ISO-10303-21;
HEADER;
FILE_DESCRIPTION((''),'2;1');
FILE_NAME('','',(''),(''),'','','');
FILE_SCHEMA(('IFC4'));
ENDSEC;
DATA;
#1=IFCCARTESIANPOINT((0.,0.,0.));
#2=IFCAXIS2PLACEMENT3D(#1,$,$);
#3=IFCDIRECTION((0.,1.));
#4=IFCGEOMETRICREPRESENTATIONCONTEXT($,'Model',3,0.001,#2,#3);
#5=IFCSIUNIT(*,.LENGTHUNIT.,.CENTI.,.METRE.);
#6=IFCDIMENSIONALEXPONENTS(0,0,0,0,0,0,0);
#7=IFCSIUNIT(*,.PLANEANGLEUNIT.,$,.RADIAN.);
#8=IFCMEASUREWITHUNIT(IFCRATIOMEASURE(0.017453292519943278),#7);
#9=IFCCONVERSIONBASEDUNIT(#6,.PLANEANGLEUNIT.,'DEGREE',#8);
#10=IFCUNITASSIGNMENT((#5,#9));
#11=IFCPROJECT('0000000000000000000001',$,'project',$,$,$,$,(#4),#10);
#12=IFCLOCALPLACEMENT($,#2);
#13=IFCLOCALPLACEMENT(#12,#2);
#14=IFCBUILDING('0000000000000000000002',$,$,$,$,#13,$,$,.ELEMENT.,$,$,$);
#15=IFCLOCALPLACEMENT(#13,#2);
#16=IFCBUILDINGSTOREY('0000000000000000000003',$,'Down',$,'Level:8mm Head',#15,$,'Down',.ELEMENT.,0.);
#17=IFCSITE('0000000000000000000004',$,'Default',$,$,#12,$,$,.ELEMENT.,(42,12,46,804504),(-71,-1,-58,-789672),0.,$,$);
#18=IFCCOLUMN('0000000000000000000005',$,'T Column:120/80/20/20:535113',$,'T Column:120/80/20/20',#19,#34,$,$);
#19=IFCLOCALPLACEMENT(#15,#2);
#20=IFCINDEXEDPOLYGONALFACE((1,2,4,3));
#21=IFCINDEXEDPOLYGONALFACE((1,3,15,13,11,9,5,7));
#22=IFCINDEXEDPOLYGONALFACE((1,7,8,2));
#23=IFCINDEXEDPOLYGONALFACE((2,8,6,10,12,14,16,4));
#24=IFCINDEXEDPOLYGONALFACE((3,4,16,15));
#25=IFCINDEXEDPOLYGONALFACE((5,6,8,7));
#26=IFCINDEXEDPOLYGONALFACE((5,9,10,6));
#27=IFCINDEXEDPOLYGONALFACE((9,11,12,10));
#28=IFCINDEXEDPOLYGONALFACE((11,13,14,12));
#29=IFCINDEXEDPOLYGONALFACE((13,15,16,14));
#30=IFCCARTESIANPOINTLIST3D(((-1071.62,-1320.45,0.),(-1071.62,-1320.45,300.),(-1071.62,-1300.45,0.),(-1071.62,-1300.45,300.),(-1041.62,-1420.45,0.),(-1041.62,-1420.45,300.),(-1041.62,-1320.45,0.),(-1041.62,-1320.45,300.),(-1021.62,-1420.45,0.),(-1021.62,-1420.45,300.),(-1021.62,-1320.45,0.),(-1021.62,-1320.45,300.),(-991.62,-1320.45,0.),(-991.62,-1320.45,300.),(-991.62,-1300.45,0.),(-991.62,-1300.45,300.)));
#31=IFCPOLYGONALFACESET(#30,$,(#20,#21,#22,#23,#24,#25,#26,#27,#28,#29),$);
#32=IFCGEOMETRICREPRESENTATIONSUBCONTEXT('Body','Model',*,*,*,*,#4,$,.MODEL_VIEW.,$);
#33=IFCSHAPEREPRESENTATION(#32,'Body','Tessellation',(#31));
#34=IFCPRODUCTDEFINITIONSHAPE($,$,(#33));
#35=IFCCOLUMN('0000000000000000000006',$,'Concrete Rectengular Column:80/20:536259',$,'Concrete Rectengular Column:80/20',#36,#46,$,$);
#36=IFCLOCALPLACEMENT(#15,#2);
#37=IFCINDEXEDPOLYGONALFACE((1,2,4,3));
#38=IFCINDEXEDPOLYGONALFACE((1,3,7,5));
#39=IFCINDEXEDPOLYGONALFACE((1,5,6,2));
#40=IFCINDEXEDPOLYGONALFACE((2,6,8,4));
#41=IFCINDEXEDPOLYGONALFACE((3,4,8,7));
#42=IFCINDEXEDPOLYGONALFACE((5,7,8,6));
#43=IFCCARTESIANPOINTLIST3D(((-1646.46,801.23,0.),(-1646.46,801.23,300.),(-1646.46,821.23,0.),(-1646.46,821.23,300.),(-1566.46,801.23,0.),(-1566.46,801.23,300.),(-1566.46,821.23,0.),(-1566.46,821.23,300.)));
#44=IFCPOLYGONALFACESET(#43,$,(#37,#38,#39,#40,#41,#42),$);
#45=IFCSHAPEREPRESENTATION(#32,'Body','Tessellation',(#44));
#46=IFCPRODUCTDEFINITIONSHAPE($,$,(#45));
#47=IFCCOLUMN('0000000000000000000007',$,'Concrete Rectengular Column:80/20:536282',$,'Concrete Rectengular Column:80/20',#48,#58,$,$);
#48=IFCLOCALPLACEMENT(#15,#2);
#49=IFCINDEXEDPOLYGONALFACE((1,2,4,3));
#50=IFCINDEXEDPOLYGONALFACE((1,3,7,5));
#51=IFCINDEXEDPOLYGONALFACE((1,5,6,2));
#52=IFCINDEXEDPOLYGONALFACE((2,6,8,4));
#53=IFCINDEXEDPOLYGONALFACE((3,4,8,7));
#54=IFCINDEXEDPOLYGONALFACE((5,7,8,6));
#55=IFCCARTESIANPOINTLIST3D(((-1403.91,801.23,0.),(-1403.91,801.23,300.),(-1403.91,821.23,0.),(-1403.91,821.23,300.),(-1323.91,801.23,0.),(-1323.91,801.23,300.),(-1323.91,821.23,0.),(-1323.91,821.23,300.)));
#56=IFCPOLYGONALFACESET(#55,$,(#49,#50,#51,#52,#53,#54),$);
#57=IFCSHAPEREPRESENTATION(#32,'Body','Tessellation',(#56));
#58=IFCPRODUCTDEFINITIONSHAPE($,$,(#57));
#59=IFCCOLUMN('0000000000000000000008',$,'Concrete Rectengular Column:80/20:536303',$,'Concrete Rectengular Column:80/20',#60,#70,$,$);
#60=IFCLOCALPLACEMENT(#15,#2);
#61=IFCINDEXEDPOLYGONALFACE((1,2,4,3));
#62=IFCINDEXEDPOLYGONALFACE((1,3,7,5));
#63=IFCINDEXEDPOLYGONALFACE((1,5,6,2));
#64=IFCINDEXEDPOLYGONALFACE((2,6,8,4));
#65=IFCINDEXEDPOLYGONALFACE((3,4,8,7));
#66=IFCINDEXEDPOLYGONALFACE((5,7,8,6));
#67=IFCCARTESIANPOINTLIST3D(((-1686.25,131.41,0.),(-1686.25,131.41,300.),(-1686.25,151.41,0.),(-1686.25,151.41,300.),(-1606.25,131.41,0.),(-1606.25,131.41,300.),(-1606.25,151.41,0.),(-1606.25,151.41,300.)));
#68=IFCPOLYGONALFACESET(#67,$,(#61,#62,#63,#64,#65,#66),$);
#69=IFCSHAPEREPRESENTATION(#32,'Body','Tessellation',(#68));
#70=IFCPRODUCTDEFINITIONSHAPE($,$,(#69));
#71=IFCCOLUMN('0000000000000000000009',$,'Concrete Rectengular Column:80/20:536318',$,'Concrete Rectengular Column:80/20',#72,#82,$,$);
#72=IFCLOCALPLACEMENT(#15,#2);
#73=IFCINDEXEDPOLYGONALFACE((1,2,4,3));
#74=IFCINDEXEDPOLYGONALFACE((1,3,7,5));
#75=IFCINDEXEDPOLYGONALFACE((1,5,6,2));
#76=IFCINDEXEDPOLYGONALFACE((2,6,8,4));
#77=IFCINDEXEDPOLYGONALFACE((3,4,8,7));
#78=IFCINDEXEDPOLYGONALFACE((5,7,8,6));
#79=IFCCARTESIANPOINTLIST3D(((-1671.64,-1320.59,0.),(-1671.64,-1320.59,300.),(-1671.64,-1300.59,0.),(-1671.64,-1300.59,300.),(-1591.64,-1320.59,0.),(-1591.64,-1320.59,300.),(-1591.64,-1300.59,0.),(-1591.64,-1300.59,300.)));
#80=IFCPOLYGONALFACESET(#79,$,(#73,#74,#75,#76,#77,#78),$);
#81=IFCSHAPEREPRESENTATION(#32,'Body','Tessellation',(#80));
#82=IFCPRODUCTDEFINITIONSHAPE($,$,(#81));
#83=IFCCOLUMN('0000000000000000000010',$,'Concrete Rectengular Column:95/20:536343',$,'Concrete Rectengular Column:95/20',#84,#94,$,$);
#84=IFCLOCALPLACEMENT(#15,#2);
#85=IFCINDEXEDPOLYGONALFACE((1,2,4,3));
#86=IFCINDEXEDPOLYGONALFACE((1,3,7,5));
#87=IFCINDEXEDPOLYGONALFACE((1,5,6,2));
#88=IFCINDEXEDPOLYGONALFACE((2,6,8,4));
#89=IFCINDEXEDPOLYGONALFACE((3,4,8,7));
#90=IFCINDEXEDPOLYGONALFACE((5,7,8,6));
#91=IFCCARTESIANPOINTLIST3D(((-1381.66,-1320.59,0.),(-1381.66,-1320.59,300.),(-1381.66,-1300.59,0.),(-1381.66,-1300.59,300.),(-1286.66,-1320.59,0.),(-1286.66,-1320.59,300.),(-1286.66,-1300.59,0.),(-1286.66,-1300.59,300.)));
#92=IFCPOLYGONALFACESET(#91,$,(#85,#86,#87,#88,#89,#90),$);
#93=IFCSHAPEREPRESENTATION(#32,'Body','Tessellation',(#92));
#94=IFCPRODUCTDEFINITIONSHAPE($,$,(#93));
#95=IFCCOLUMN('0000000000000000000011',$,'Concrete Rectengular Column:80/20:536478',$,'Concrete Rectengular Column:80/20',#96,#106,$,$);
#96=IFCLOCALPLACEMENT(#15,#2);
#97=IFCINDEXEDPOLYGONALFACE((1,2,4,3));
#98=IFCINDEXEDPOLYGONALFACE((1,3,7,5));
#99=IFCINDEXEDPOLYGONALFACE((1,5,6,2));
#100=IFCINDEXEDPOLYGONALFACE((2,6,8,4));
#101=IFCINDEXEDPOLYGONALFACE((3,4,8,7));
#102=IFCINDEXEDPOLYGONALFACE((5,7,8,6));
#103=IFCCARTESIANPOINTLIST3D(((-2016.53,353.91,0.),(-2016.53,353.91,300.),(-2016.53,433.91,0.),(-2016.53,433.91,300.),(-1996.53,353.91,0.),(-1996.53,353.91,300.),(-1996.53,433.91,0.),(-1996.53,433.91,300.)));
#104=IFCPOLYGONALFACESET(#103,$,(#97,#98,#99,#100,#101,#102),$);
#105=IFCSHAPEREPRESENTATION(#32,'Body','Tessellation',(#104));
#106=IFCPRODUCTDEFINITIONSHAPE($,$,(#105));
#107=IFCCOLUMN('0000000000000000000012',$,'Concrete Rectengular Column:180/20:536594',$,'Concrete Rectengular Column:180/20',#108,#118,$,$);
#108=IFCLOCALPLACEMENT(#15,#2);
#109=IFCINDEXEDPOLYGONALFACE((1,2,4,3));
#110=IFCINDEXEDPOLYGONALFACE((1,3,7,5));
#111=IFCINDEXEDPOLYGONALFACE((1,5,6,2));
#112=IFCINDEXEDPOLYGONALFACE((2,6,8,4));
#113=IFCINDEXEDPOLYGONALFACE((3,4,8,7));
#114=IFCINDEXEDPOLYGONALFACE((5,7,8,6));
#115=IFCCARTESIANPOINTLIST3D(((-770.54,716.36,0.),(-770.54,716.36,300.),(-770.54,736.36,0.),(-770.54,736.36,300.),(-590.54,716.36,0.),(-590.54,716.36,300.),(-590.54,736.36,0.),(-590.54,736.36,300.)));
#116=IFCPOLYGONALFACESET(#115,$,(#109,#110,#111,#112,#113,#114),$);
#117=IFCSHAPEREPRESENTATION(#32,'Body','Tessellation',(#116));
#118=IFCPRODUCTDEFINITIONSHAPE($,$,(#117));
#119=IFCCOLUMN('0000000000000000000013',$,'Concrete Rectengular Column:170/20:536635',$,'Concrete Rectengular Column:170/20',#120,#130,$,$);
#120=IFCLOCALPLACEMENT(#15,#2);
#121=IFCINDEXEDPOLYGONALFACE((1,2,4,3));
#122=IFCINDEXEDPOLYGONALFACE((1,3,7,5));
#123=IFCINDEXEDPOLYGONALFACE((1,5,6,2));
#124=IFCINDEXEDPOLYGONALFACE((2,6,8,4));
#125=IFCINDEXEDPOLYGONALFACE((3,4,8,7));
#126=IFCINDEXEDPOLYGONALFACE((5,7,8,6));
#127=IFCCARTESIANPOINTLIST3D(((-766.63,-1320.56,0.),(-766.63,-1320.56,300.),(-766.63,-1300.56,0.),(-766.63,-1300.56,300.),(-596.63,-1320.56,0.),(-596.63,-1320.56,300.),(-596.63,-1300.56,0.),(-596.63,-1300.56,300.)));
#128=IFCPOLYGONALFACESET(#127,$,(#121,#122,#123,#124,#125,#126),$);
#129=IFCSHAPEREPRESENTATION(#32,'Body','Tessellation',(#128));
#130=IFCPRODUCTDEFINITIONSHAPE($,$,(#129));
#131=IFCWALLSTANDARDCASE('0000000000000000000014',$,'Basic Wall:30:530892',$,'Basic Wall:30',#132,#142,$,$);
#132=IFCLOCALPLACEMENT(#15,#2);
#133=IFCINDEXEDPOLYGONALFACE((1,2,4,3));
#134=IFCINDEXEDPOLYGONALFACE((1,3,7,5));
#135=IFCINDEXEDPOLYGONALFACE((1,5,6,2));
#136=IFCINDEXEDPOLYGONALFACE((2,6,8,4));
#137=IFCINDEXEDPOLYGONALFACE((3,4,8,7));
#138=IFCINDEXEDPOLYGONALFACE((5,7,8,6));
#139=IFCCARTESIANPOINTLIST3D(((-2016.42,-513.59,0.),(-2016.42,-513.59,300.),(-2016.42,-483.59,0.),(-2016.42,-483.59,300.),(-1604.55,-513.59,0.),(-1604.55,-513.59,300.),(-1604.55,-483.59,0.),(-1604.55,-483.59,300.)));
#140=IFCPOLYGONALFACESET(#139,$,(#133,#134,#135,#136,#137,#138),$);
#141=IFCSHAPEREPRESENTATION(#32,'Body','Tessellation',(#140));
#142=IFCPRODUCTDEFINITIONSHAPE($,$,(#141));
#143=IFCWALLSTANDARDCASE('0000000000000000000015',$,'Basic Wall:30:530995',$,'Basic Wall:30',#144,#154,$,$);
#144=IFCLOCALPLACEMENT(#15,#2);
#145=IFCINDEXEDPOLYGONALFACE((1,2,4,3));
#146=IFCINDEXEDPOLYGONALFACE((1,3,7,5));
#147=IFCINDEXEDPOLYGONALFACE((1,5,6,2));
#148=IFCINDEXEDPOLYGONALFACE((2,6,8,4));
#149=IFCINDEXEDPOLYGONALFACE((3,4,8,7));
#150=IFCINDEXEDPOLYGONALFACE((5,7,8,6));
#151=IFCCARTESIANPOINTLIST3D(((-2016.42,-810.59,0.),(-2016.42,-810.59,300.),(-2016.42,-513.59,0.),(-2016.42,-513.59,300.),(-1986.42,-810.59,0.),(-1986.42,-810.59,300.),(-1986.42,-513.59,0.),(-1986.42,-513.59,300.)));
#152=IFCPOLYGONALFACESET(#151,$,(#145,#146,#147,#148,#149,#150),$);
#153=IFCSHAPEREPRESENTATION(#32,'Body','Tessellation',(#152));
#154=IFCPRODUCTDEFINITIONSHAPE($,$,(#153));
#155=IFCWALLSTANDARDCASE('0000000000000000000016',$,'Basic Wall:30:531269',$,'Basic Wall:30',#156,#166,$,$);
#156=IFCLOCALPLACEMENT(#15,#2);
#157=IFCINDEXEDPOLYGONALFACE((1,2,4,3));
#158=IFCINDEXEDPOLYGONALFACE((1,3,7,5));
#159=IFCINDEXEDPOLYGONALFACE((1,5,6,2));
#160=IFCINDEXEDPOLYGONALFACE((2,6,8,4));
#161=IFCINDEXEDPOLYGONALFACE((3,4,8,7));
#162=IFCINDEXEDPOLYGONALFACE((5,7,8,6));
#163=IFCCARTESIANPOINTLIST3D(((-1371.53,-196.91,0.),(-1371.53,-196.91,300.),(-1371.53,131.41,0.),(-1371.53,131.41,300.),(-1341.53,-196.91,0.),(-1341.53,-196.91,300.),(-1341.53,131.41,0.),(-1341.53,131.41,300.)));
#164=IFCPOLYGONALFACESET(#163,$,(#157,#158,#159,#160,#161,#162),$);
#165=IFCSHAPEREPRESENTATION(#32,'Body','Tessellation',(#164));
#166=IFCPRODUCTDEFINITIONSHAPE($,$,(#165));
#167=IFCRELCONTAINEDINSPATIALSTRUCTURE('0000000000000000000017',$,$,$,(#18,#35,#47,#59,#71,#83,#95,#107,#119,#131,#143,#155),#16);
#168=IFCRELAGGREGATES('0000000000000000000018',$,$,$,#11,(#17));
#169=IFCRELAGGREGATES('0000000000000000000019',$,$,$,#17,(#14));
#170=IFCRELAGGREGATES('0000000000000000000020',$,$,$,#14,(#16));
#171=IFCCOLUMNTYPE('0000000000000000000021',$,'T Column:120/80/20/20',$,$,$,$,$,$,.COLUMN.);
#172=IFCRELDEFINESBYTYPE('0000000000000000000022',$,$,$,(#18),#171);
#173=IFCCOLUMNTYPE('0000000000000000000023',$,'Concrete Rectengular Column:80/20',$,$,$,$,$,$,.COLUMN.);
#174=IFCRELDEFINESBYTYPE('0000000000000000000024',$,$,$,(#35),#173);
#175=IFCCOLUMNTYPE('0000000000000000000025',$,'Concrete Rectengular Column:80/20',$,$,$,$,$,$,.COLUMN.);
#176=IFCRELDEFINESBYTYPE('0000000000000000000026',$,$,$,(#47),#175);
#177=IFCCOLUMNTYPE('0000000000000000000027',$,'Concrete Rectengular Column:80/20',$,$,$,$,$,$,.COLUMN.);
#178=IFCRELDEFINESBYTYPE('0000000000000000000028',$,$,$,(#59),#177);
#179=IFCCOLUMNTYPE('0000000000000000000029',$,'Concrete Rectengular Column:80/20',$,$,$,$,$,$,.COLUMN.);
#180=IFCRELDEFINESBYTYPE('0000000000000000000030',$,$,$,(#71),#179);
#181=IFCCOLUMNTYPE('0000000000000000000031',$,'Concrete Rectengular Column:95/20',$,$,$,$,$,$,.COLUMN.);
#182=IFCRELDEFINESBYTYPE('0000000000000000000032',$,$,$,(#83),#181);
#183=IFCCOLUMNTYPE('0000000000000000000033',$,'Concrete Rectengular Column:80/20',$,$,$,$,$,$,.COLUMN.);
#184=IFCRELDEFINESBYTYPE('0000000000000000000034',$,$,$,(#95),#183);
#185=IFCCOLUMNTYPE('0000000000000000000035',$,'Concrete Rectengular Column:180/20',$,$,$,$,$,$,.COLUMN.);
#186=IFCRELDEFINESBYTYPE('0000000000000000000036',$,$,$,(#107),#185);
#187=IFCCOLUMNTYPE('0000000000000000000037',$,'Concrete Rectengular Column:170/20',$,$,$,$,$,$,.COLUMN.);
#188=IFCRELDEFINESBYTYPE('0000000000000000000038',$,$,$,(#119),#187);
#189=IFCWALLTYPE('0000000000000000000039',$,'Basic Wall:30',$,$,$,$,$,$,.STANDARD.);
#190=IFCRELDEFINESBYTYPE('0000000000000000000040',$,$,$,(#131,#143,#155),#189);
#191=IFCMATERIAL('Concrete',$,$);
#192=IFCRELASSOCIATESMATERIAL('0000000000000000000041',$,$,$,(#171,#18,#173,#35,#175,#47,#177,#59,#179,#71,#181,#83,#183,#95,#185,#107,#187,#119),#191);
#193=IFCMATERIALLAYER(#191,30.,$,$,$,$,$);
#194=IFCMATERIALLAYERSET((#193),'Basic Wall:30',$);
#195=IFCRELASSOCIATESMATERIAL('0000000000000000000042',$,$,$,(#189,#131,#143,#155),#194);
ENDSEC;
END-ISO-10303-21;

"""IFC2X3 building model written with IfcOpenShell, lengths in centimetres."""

from ifc_helpers import new_model, entity, si_unit, converted_unit, direction, frame, frame_2d, origin, origin_2d_with_axis, place, context, subcontext, project, spatial, polyline, rectangle, outline, extrude, source, transform, mapped, material, layer, layer_set, layer_usage, type_object, type_shapes, element, save


model = new_model("IFC2X3")

# Units and contexts
model_context = context("Model", 3, precision=0.001, world=origin(), true_north=direction((0.0, 1.0)))
body_context = subcontext(model_context, "Body", "Model", "MODEL_VIEW")
ifc_project = project(units=[si_unit("LENGTHUNIT", "METRE", prefix="CENTI"), converted_unit("PLANEANGLEUNIT", "DEGREE", entity("IfcRatioMeasure", 0.017453292519943278), si_unit("PLANEANGLEUNIT", "RADIAN"), dimensions=[0, 0, 0, 0, 0, 0, 0])], contexts=[model_context])

# Site, building, storey
site_placement = place(None, origin())
site = spatial("IfcSite", under=ifc_project, at=site_placement, Name="Default", CompositionType="ELEMENT", RefLatitude=(42, 12, 46, 804504), RefLongitude=(-71, -1, -58, -789672), RefElevation=0.0)
building_placement = place(site_placement, origin())
building = spatial("IfcBuilding", under=site, at=building_placement, CompositionType="ELEMENT")
storey_placement = place(building_placement, origin())
storey = spatial("IfcBuildingStorey", under=building, at=storey_placement, Name="Down", ObjectType="Level:8mm Head", LongName="Down", CompositionType="ELEMENT", Elevation=0.0)

# Columns
ifc_material = material(Name="Concrete")
column_type_1 = type_object("IfcColumnType", Name="T Column:120/80/20/20", PredefinedType="COLUMN", material=ifc_material)
shared_shape_1 = source(origin(), body_context, "Body", "SweptSolid", [
    extrude(outline(polyline([(-40.0, -40.0), (-20.0, -40.0), (-20.0, -10.0), (80.0, -10.0), (80.0, 10.0), (-20.0, 10.0), (-20.0, 40.0), (-40.0, 40.0), (-40.0, -40.0)])), frame((-1031.62, -1340.45, 0.0), z_axis=(0.0, 0.0, 1.0), x_axis=(0.0, -1.0, 0.0)), (0.0, 0.0, 1.0), 300.0),
])
type_shapes(column_type_1, [shared_shape_1])
column_1_placement = place(storey_placement, origin())
element("IfcColumn", 1, at=column_1_placement, inside=storey, type_object=column_type_1, material=ifc_material, Name="T Column:120/80/20/20:535113", ObjectType="T Column:120/80/20/20", context=body_context, shape_type="MappedRepresentation", body=[
    mapped(shared_shape_1, transform((0.0, 0.0, 0.0), scale=1.0)),
])
column_type_2 = type_object("IfcColumnType", Name="Concrete Rectengular Column:80/20", PredefinedType="COLUMN", material=ifc_material)
shared_shape_2 = source(origin(), body_context, "Body", "SweptSolid", [
    extrude(rectangle(XDim=20.0, YDim=80.0, at=origin_2d_with_axis()), frame((-1606.46, 811.23, 0.0), z_axis=(0.0, 0.0, 1.0), x_axis=(0.0, -1.0, 0.0)), (0.0, 0.0, 1.0), 300.0),
])
type_shapes(column_type_2, [shared_shape_2])
column_2_placement = place(storey_placement, origin())
element("IfcColumn", 2, at=column_2_placement, inside=storey, type_object=column_type_2, material=ifc_material, Name="Concrete Rectengular Column:80/20:536259", ObjectType="Concrete Rectengular Column:80/20", context=body_context, shape_type="MappedRepresentation", body=[
    mapped(shared_shape_2, transform((0.0, 0.0, 0.0), scale=1.0)),
])
column_type_3 = type_object("IfcColumnType", Name="Concrete Rectengular Column:80/20", PredefinedType="COLUMN", material=ifc_material)
shared_shape_3 = source(origin(), body_context, "Body", "SweptSolid", [
    extrude(rectangle(XDim=20.0, YDim=80.0, at=origin_2d_with_axis()), frame((-1363.91, 811.23, 0.0), z_axis=(0.0, 0.0, 1.0), x_axis=(0.0, -1.0, 0.0)), (0.0, 0.0, 1.0), 300.0),
])
type_shapes(column_type_3, [shared_shape_3])
column_3_placement = place(storey_placement, origin())
element("IfcColumn", 3, at=column_3_placement, inside=storey, type_object=column_type_3, material=ifc_material, Name="Concrete Rectengular Column:80/20:536282", ObjectType="Concrete Rectengular Column:80/20", context=body_context, shape_type="MappedRepresentation", body=[
    mapped(shared_shape_3, transform((0.0, 0.0, 0.0), scale=1.0)),
])
column_type_4 = type_object("IfcColumnType", Name="Concrete Rectengular Column:80/20", PredefinedType="COLUMN", material=ifc_material)
shared_shape_4 = source(origin(), body_context, "Body", "SweptSolid", [
    extrude(rectangle(XDim=20.0, YDim=80.0, at=frame_2d((0.0, 0.0), x_axis=(1.0, 0.0))), frame((-1646.25, 141.41, 0.0), z_axis=(0.0, 0.0, 1.0), x_axis=(0.0, -1.0, 0.0)), (0.0, 0.0, 1.0), 300.0),
])
type_shapes(column_type_4, [shared_shape_4])
column_4_placement = place(storey_placement, origin())
element("IfcColumn", 4, at=column_4_placement, inside=storey, type_object=column_type_4, material=ifc_material, Name="Concrete Rectengular Column:80/20:536303", ObjectType="Concrete Rectengular Column:80/20", context=body_context, shape_type="MappedRepresentation", body=[
    mapped(shared_shape_4, transform((0.0, 0.0, 0.0), scale=1.0)),
])
column_type_5 = type_object("IfcColumnType", Name="Concrete Rectengular Column:80/20", PredefinedType="COLUMN", material=ifc_material)
shared_shape_5 = source(origin(), body_context, "Body", "SweptSolid", [
    extrude(rectangle(XDim=20.0, YDim=80.0, at=frame_2d((0.0, 0.0), x_axis=(1.0, 0.0))), frame((-1631.64, -1310.59, 0.0), z_axis=(0.0, 0.0, 1.0), x_axis=(0.0, -1.0, 0.0)), (0.0, 0.0, 1.0), 300.0),
])
type_shapes(column_type_5, [shared_shape_5])
column_5_placement = place(storey_placement, origin())
element("IfcColumn", 5, at=column_5_placement, inside=storey, type_object=column_type_5, material=ifc_material, Name="Concrete Rectengular Column:80/20:536318", ObjectType="Concrete Rectengular Column:80/20", context=body_context, shape_type="MappedRepresentation", body=[
    mapped(shared_shape_5, transform((0.0, 0.0, 0.0), scale=1.0)),
])
column_type_6 = type_object("IfcColumnType", Name="Concrete Rectengular Column:95/20", PredefinedType="COLUMN", material=ifc_material)
shared_shape_6 = source(origin(), body_context, "Body", "SweptSolid", [
    extrude(rectangle(XDim=20.0, YDim=95.0, at=frame_2d((0.0, 0.0), x_axis=(1.0, 0.0))), frame((-1334.16, -1310.59, 0.0), z_axis=(0.0, 0.0, 1.0), x_axis=(0.0, -1.0, 0.0)), (0.0, 0.0, 1.0), 300.0),
])
type_shapes(column_type_6, [shared_shape_6])
column_6_placement = place(storey_placement, origin())
element("IfcColumn", 6, at=column_6_placement, inside=storey, type_object=column_type_6, material=ifc_material, Name="Concrete Rectengular Column:95/20:536343", ObjectType="Concrete Rectengular Column:95/20", context=body_context, shape_type="MappedRepresentation", body=[
    mapped(shared_shape_6, transform((0.0, 0.0, 0.0), scale=1.0)),
])
column_type_7 = type_object("IfcColumnType", Name="Concrete Rectengular Column:80/20", PredefinedType="COLUMN", material=ifc_material)
shared_shape_7 = source(origin(), body_context, "Body", "SweptSolid", [
    extrude(rectangle(XDim=80.0, YDim=20.0, at=origin_2d_with_axis()), frame((-2006.53, 393.91, 0.0), z_axis=(0.0, 0.0, 1.0), x_axis=(0.0, -1.0, 0.0)), (0.0, 0.0, 1.0), 300.0),
])
type_shapes(column_type_7, [shared_shape_7])
column_7_placement = place(storey_placement, origin())
element("IfcColumn", 7, at=column_7_placement, inside=storey, type_object=column_type_7, material=ifc_material, Name="Concrete Rectengular Column:80/20:536478", ObjectType="Concrete Rectengular Column:80/20", context=body_context, shape_type="MappedRepresentation", body=[
    mapped(shared_shape_7, transform((0.0, 0.0, 0.0), scale=1.0)),
])
column_type_8 = type_object("IfcColumnType", Name="Concrete Rectengular Column:180/20", PredefinedType="COLUMN", material=ifc_material)
shared_shape_8 = source(origin(), body_context, "Body", "SweptSolid", [
    extrude(rectangle(XDim=20.0, YDim=180.0, at=origin_2d_with_axis()), frame((-680.54, 726.36, 0.0), z_axis=(0.0, 0.0, 1.0), x_axis=(0.0, -1.0, 0.0)), (0.0, 0.0, 1.0), 300.0),
])
type_shapes(column_type_8, [shared_shape_8])
column_8_placement = place(storey_placement, origin())
element("IfcColumn", 8, at=column_8_placement, inside=storey, type_object=column_type_8, material=ifc_material, Name="Concrete Rectengular Column:180/20:536594", ObjectType="Concrete Rectengular Column:180/20", context=body_context, shape_type="MappedRepresentation", body=[
    mapped(shared_shape_8, transform((0.0, 0.0, 0.0), scale=1.0)),
])
column_type_9 = type_object("IfcColumnType", Name="Concrete Rectengular Column:170/20", PredefinedType="COLUMN", material=ifc_material)
shared_shape_9 = source(origin(), body_context, "Body", "SweptSolid", [
    extrude(rectangle(XDim=20.0, YDim=170.0, at=frame_2d((0.0, 0.0), x_axis=(1.0, 0.0))), frame((-681.63, -1310.56, 0.0), z_axis=(0.0, 0.0, 1.0), x_axis=(0.0, -1.0, 0.0)), (0.0, 0.0, 1.0), 300.0),
])
type_shapes(column_type_9, [shared_shape_9])
column_9_placement = place(storey_placement, origin())
element("IfcColumn", 9, at=column_9_placement, inside=storey, type_object=column_type_9, material=ifc_material, Name="Concrete Rectengular Column:170/20:536635", ObjectType="Concrete Rectengular Column:170/20", context=body_context, shape_type="MappedRepresentation", body=[
    mapped(shared_shape_9, transform((0.0, 0.0, 0.0), scale=1.0)),
])

# Walls
ifc_layer_1 = layer(ifc_material, 30.0)
ifc_layer_set_1 = layer_set([ifc_layer_1], Name="Basic Wall:30")
ifc_layer_usage_1 = layer_usage(ifc_layer_set_1, "AXIS2", "NEGATIVE", 15.0)
wall_type_1 = type_object("IfcWallType", Name="Basic Wall:30", PredefinedType="STANDARD", material=ifc_layer_set_1)
wall_1_placement = place(storey_placement, frame((-2016.42, -498.59, 0.0)))
element("IfcWallStandardCase", 10, at=wall_1_placement, inside=storey, type_object=wall_type_1, material=ifc_layer_usage_1, Name="Basic Wall:30:530892", ObjectType="Basic Wall:30", context=body_context, shape_type="SweptSolid", body=[
    extrude(rectangle(XDim=411.87, YDim=30.0, at=frame_2d((205.94, 0.0), x_axis=(-1.0, 0.0))), origin(), (0.0, 0.0, 1.0), 300.0),
])
ifc_layer_usage_2 = layer_usage(ifc_layer_set_1, "AXIS2", "POSITIVE", -15.0)
wall_2_placement = place(storey_placement, frame((-2001.42, -513.59, 0.0), z_axis=(0.0, 0.0, 1.0), x_axis=(0.0, -1.0, 0.0)))
element("IfcWallStandardCase", 11, at=wall_2_placement, inside=storey, type_object=wall_type_1, material=ifc_layer_usage_2, Name="Basic Wall:30:530995", ObjectType="Basic Wall:30", context=body_context, shape_type="SweptSolid", body=[
    extrude(rectangle(XDim=297.0, YDim=30.0, at=frame_2d((148.5, 0.0), x_axis=(-1.0, 0.0))), origin(), (0.0, 0.0, 1.0), 300.0),
])
ifc_layer_usage_3 = layer_usage(ifc_layer_set_1, "AXIS2", "NEGATIVE", 15.0)
wall_3_placement = place(storey_placement, frame((-1356.53, -196.91, 0.0), z_axis=(0.0, 0.0, 1.0), x_axis=(0.0, 1.0, 0.0)))
element("IfcWallStandardCase", 12, at=wall_3_placement, inside=storey, type_object=wall_type_1, material=ifc_layer_usage_3, Name="Basic Wall:30:531269", ObjectType="Basic Wall:30", context=body_context, shape_type="SweptSolid", body=[
    extrude(rectangle(XDim=328.32, YDim=30.0, at=frame_2d((164.16, 0.0), x_axis=(-1.0, 0.0))), origin(), (0.0, 0.0, 1.0), 300.0),
])

save(model, "model.ifc")
